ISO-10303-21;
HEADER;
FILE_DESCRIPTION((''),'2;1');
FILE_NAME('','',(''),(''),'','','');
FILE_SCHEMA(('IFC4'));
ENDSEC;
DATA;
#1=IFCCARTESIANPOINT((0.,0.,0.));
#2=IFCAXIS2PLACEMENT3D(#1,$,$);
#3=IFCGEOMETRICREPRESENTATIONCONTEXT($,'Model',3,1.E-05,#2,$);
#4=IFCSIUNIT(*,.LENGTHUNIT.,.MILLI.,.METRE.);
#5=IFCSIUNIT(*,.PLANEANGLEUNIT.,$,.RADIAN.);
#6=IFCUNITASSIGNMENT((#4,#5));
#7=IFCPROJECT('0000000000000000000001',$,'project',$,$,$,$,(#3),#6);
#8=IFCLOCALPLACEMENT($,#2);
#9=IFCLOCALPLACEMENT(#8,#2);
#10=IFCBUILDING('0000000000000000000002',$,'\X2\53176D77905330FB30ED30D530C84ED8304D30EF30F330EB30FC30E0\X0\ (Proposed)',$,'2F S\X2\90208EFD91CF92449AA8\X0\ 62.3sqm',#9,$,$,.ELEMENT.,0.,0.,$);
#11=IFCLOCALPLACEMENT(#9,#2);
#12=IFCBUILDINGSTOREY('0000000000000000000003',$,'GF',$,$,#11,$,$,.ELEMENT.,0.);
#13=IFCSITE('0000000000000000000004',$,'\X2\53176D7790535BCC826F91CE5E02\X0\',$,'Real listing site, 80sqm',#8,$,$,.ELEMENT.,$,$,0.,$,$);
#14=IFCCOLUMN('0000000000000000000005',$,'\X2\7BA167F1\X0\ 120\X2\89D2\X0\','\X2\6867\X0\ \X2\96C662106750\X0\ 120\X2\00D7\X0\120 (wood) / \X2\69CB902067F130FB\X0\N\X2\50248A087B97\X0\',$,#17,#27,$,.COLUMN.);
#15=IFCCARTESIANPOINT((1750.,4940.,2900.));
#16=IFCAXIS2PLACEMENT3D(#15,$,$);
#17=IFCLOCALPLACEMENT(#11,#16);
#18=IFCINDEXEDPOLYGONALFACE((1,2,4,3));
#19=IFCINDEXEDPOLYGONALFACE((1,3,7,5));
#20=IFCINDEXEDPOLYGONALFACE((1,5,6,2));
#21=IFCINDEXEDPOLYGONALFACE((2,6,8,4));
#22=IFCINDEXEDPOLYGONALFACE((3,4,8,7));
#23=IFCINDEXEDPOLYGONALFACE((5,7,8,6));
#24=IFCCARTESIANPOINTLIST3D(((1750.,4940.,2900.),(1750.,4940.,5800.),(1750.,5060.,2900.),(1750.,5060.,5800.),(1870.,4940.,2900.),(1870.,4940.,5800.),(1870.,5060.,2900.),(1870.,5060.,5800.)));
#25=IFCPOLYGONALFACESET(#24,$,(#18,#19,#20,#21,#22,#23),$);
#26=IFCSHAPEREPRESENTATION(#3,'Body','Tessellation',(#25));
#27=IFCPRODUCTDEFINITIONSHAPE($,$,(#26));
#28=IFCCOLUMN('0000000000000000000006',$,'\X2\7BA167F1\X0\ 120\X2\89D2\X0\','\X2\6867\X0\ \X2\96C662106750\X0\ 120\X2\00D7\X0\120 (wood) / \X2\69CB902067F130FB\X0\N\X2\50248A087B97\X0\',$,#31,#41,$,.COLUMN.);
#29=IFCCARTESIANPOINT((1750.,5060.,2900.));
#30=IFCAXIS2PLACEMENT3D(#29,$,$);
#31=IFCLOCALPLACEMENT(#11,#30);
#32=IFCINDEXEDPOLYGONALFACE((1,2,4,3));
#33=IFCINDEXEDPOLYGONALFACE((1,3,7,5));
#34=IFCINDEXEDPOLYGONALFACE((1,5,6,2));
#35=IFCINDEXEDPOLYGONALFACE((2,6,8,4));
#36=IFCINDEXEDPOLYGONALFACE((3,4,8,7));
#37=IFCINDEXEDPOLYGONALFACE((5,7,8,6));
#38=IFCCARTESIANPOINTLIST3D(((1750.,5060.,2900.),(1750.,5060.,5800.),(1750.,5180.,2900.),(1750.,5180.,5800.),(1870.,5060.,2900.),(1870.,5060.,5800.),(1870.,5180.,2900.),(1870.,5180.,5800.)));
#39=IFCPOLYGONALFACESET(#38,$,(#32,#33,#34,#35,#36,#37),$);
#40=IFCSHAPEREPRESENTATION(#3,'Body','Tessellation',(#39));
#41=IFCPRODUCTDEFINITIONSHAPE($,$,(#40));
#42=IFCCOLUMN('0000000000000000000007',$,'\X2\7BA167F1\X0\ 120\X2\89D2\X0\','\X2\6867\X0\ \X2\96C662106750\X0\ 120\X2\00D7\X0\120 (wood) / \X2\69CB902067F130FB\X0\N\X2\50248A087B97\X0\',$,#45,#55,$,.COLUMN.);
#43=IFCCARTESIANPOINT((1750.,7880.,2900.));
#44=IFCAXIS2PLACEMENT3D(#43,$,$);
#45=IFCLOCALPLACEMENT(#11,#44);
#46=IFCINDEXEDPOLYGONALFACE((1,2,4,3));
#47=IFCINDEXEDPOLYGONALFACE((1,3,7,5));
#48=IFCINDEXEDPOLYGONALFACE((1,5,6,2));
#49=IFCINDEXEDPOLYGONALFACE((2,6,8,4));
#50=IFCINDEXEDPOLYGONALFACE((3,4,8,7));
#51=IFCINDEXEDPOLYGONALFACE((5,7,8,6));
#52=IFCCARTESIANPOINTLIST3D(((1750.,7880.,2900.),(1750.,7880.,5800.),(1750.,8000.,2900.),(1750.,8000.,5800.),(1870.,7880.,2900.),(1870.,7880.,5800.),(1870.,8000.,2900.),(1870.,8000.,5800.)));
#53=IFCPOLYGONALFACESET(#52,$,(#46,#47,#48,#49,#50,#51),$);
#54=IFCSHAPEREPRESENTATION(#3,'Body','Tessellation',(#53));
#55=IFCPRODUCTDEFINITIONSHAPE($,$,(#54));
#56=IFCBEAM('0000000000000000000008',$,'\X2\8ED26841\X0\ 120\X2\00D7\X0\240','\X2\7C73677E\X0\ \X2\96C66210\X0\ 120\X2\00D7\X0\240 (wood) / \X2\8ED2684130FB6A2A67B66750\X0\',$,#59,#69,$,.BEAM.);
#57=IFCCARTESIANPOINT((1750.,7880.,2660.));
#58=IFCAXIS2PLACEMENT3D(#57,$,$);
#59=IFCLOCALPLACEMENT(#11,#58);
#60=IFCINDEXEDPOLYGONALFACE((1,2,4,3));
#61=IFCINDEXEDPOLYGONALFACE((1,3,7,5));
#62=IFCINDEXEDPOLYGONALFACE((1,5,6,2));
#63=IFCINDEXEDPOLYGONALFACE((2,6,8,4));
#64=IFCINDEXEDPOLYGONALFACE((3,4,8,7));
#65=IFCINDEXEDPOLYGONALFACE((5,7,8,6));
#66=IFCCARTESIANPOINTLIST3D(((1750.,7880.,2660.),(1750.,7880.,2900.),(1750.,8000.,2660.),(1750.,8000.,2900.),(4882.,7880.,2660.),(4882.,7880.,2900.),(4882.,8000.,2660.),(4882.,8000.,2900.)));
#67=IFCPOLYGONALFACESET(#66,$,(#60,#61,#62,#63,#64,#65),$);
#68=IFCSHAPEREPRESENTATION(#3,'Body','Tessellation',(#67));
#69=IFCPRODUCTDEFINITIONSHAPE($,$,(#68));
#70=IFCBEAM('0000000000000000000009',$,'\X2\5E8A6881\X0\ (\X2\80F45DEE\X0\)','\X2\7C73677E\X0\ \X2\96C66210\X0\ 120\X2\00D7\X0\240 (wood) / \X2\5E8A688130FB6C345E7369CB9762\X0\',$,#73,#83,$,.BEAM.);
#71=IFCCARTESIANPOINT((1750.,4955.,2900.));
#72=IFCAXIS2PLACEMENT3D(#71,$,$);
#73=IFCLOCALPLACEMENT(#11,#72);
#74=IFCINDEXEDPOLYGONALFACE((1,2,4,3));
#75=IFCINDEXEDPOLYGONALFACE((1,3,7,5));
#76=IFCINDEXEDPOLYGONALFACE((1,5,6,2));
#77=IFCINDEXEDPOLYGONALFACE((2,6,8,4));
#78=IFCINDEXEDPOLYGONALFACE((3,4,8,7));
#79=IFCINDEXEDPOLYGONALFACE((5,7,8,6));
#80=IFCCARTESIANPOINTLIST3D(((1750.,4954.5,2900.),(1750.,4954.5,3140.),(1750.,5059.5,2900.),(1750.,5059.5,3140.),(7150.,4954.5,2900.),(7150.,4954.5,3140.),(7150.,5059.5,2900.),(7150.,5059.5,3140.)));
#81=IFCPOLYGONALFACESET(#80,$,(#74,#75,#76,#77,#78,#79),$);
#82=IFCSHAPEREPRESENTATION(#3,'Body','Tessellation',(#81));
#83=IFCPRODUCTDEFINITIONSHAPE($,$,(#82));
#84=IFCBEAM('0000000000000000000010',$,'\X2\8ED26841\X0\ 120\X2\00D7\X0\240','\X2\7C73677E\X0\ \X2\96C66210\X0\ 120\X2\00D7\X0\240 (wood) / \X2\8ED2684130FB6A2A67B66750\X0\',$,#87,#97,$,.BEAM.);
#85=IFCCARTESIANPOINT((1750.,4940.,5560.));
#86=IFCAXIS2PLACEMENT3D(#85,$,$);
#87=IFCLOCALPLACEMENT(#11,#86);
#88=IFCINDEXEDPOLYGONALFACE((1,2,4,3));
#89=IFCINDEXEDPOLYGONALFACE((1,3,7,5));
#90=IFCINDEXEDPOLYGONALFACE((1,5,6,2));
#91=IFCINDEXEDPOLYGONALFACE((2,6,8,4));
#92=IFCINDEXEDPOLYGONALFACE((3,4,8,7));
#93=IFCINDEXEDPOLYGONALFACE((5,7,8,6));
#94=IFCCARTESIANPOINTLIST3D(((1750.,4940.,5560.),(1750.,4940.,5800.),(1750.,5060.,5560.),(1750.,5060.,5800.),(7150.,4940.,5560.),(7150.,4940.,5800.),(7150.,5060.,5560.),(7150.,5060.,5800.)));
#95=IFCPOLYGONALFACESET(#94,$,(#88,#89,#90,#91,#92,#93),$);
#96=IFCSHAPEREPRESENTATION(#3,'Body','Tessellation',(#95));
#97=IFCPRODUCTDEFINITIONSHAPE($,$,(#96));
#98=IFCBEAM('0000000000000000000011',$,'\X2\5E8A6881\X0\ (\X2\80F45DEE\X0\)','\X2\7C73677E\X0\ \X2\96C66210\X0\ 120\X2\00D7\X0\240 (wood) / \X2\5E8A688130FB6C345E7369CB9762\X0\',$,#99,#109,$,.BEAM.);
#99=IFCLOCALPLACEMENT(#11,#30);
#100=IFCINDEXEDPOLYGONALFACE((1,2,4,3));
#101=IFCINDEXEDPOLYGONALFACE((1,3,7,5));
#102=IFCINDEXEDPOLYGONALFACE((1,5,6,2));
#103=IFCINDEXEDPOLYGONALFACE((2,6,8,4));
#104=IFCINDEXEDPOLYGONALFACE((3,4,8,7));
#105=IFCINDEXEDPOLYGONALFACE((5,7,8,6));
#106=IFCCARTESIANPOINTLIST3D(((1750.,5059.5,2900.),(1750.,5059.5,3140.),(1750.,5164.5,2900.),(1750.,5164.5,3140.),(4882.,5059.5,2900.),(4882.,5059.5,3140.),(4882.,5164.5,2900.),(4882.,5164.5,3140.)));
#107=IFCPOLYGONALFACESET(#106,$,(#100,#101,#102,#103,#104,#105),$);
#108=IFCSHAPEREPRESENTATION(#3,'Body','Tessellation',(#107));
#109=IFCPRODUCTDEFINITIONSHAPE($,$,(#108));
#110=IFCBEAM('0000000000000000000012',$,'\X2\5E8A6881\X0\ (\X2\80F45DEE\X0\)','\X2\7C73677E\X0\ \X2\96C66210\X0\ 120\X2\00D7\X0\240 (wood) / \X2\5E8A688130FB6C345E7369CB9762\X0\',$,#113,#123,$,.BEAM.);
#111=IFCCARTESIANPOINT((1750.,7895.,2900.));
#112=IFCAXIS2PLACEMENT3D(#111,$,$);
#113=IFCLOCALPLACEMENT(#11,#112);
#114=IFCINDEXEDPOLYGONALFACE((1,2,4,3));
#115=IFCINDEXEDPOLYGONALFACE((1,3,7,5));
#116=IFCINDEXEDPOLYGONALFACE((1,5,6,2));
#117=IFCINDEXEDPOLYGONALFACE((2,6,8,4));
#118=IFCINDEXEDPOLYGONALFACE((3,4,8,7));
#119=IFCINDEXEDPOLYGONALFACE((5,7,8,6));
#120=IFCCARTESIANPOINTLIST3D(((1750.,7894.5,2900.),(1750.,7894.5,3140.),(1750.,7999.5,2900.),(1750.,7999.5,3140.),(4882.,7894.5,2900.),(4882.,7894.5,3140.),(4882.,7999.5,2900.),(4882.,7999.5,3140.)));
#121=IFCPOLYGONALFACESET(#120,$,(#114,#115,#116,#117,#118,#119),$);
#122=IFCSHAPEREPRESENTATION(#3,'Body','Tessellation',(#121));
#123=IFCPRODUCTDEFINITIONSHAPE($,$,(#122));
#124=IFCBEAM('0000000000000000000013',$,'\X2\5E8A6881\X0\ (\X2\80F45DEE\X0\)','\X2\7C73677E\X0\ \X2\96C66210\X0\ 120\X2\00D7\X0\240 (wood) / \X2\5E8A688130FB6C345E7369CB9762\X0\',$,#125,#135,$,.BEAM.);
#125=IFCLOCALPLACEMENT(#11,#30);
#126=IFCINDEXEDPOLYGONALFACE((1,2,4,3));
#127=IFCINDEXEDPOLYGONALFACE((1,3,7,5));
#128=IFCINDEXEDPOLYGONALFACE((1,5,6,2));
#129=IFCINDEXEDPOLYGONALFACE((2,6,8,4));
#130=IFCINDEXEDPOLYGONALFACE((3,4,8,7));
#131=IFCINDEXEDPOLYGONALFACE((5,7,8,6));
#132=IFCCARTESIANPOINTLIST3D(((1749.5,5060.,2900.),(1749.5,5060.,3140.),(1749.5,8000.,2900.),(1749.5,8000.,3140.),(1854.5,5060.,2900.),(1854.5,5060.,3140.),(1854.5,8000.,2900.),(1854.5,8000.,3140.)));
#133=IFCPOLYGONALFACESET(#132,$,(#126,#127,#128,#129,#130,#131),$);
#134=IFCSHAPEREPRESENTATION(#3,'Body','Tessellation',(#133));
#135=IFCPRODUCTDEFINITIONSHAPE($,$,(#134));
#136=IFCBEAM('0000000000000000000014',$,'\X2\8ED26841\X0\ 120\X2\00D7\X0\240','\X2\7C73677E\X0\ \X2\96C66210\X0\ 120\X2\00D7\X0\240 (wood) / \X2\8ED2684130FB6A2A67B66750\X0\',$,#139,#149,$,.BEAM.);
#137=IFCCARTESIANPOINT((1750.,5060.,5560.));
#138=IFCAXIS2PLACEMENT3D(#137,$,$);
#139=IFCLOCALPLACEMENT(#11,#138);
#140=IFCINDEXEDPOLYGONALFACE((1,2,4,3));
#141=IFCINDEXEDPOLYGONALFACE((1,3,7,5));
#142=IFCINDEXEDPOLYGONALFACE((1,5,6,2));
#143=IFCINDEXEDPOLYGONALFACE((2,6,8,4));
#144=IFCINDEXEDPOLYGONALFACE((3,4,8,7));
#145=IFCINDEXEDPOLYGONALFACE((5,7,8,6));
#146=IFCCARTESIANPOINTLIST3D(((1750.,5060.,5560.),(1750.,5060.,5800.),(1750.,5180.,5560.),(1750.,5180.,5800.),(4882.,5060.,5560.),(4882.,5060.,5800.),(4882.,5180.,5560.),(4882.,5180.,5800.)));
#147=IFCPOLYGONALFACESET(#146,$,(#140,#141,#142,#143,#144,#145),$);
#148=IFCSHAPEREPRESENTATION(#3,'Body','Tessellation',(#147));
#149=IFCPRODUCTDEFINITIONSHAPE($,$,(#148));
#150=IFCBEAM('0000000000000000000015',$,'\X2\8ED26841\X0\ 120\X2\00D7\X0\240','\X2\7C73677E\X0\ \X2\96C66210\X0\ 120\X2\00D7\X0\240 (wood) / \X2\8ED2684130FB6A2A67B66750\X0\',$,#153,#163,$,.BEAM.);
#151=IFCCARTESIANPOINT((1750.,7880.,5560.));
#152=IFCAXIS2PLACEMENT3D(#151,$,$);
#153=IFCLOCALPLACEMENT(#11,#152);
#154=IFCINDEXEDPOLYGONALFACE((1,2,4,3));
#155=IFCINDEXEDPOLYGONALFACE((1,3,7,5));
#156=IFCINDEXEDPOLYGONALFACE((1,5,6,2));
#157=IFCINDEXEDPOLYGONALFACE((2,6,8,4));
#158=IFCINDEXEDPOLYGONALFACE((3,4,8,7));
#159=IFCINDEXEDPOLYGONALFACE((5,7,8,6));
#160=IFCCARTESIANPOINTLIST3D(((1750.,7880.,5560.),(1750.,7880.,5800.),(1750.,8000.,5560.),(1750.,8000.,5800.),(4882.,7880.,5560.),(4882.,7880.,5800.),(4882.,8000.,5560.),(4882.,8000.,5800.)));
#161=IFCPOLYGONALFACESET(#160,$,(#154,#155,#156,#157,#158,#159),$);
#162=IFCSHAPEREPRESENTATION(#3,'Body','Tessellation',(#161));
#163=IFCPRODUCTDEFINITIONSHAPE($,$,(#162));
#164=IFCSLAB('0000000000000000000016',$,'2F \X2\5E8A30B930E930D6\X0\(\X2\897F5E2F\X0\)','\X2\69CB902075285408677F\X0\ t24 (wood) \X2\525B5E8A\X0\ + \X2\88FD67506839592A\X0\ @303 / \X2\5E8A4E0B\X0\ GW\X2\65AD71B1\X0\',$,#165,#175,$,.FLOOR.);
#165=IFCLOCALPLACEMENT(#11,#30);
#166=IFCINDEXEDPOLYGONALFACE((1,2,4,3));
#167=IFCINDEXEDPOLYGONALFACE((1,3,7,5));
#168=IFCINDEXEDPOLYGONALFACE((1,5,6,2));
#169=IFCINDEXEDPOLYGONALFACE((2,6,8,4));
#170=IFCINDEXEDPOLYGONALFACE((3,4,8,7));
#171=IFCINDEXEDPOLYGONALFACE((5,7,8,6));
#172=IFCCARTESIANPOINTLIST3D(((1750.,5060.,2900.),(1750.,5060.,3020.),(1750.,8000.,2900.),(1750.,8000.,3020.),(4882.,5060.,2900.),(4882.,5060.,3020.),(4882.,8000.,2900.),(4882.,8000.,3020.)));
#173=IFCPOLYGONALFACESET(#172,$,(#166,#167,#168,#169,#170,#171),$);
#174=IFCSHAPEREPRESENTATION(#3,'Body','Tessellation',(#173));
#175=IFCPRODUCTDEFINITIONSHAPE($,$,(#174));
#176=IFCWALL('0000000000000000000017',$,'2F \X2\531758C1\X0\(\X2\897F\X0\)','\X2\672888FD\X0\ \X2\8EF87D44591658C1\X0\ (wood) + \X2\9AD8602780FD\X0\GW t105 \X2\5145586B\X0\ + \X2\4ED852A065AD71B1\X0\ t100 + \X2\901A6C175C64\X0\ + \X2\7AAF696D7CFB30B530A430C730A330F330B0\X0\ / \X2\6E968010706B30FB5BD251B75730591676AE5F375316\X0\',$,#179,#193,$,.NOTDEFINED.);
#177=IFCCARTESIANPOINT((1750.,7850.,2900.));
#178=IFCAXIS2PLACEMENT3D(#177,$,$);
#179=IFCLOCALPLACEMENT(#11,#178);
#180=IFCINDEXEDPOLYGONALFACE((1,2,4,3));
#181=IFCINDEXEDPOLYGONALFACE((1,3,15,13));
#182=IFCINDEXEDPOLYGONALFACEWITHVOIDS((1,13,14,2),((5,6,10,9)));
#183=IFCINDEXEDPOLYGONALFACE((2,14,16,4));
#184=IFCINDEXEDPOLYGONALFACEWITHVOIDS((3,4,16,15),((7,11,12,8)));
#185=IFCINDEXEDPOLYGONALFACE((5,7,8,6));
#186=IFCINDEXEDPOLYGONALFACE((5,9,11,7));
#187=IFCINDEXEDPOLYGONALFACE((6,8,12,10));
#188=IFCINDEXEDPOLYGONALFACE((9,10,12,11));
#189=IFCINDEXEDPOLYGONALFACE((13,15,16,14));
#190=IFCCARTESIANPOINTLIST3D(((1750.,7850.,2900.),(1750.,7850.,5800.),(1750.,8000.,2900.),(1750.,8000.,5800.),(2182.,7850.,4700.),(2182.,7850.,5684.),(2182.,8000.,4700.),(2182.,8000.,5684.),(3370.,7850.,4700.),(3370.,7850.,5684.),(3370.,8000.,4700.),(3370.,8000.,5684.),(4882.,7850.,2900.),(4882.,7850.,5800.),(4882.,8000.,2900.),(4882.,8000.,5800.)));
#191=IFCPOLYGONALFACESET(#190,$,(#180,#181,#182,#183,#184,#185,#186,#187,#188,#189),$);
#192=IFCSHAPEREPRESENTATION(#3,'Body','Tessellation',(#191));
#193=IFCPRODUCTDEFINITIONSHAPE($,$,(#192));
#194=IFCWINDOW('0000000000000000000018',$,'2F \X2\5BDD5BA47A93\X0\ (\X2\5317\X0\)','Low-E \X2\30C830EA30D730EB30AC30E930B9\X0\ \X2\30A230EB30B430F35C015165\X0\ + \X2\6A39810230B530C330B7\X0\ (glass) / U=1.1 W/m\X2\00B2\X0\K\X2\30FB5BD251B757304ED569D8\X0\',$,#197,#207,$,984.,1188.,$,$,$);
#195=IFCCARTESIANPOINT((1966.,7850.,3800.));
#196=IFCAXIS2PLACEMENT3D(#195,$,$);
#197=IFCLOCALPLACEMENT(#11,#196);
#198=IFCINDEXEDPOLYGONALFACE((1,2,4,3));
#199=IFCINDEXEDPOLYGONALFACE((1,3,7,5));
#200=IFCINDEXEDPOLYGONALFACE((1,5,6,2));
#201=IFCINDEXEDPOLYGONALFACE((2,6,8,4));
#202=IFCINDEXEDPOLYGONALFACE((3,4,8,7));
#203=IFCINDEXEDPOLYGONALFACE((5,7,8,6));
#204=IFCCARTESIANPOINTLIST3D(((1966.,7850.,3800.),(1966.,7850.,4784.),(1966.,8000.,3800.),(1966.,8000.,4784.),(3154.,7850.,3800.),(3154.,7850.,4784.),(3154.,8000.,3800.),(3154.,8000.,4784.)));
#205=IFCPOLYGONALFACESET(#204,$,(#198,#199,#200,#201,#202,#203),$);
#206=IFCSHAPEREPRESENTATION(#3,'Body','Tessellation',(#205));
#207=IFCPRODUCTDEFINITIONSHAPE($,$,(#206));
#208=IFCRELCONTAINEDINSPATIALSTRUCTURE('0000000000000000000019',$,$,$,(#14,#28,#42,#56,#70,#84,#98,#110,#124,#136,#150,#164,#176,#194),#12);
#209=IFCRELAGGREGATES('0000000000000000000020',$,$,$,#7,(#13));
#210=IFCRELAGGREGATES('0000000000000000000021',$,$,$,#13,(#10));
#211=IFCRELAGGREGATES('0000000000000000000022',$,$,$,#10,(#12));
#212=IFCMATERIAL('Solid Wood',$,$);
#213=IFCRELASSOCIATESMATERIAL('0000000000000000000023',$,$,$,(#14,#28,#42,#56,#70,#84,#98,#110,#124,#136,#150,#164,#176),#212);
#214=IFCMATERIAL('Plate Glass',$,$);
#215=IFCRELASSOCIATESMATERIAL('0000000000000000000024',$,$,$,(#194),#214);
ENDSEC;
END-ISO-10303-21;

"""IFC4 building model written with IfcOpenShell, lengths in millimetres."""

from ifc_helpers import new_model, si_unit, frame, frame_2d, origin, place, context, project, spatial, rectangle, extrude, material, element, fill, save


model = new_model("IFC4")

# Units and contexts
model_context = context("Model", 3, precision=1e-05, world=origin())
ifc_project = project(units=[si_unit("LENGTHUNIT", "METRE", prefix="MILLI"), si_unit("PLANEANGLEUNIT", "RADIAN")], contexts=[model_context])

# Site, building, storey
site_placement = place(None, origin())
site = spatial("IfcSite", under=ifc_project, at=site_placement, Name="北海道富良野市", ObjectType="Real listing site, 80sqm", CompositionType="ELEMENT", RefElevation=0.0)
building_placement = place(site_placement, origin())
building = spatial("IfcBuilding", under=site, at=building_placement, Name="北海道・ロフト付きワンルーム (Proposed)", ObjectType="2F S造軽量鉄骨 62.3sqm", CompositionType="ELEMENT", ElevationOfRefHeight=0.0, ElevationOfTerrain=0.0)
storey_placement = place(building_placement, origin())
storey = spatial("IfcBuildingStorey", under=building, at=storey_placement, Name="GF", CompositionType="ELEMENT", Elevation=0.0)

# Columns
ifc_material_1 = material(Name="Solid Wood")
column_1_placement = place(storey_placement, frame((1750.0, 4940.0, 2900.0)))
element("IfcColumn", 1, at=column_1_placement, inside=storey, material=ifc_material_1, Name="管柱 120角", Description="桧 集成材 120×120 (wood) / 構造柱・N値計算", PredefinedType="COLUMN", context=model_context, shape_type="SweptSolid", body=[
    extrude(rectangle(XDim=120.0, YDim=120.0, at=frame_2d((60.0, 60.0))), frame((1750.0, 4940.0, 2900.0)), (0.0, 0.0, 1.0), 2900.0),
])
column_2_placement = place(storey_placement, frame((1750.0, 5060.0, 2900.0)))
element("IfcColumn", 2, at=column_2_placement, inside=storey, material=ifc_material_1, Name="管柱 120角", Description="桧 集成材 120×120 (wood) / 構造柱・N値計算", PredefinedType="COLUMN", context=model_context, shape_type="SweptSolid", body=[
    extrude(rectangle(XDim=120.0, YDim=120.0, at=frame_2d((60.0, 60.0))), frame((1750.0, 5060.0, 2900.0)), (0.0, 0.0, 1.0), 2900.0),
])
column_3_placement = place(storey_placement, frame((1750.0, 7880.0, 2900.0)))
element("IfcColumn", 3, at=column_3_placement, inside=storey, material=ifc_material_1, Name="管柱 120角", Description="桧 集成材 120×120 (wood) / 構造柱・N値計算", PredefinedType="COLUMN", context=model_context, shape_type="SweptSolid", body=[
    extrude(rectangle(XDim=120.0, YDim=120.0, at=frame_2d((60.0, 60.0))), frame((1750.0, 7880.0, 2900.0)), (0.0, 0.0, 1.0), 2900.0),
])

# Beams
beam_1_placement = place(storey_placement, frame((1750.0, 7880.0, 2660.0)))
element("IfcBeam", 4, at=beam_1_placement, inside=storey, material=ifc_material_1, Name="軒桁 120×240", Description="米松 集成 120×240 (wood) / 軒桁・横架材", PredefinedType="BEAM", context=model_context, shape_type="SweptSolid", body=[
    extrude(rectangle(XDim=3132.0, YDim=120.0, at=frame_2d((1566.0, 60.0))), frame((1750.0, 7880.0, 2660.0)), (0.0, 0.0, 1.0), 240.0),
])
beam_2_placement = place(storey_placement, frame((1750.0, 4955.0, 2900.0)))
element("IfcBeam", 5, at=beam_2_placement, inside=storey, material=ifc_material_1, Name="床梁 (胴差)", Description="米松 集成 120×240 (wood) / 床梁・水平構面", PredefinedType="BEAM", context=model_context, shape_type="SweptSolid", body=[
    extrude(rectangle(XDim=5400.0, YDim=105.0, at=frame_2d((2700.0, 52.0))), frame((1750.0, 4955.0, 2900.0)), (0.0, 0.0, 1.0), 240.0),
])
beam_3_placement = place(storey_placement, frame((1750.0, 4940.0, 5560.0)))
element("IfcBeam", 6, at=beam_3_placement, inside=storey, material=ifc_material_1, Name="軒桁 120×240", Description="米松 集成 120×240 (wood) / 軒桁・横架材", PredefinedType="BEAM", context=model_context, shape_type="SweptSolid", body=[
    extrude(rectangle(XDim=5400.0, YDim=120.0, at=frame_2d((2700.0, 60.0))), frame((1750.0, 4940.0, 5560.0)), (0.0, 0.0, 1.0), 240.0),
])
beam_4_placement = place(storey_placement, frame((1750.0, 5060.0, 2900.0)))
element("IfcBeam", 7, at=beam_4_placement, inside=storey, material=ifc_material_1, Name="床梁 (胴差)", Description="米松 集成 120×240 (wood) / 床梁・水平構面", PredefinedType="BEAM", context=model_context, shape_type="SweptSolid", body=[
    extrude(rectangle(XDim=3132.0, YDim=105.0, at=frame_2d((1566.0, 52.0))), frame((1750.0, 5060.0, 2900.0)), (0.0, 0.0, 1.0), 240.0),
])
beam_5_placement = place(storey_placement, frame((1750.0, 7895.0, 2900.0)))
element("IfcBeam", 8, at=beam_5_placement, inside=storey, material=ifc_material_1, Name="床梁 (胴差)", Description="米松 集成 120×240 (wood) / 床梁・水平構面", PredefinedType="BEAM", context=model_context, shape_type="SweptSolid", body=[
    extrude(rectangle(XDim=3132.0, YDim=105.0, at=frame_2d((1566.0, 52.0))), frame((1750.0, 7895.0, 2900.0)), (0.0, 0.0, 1.0), 240.0),
])
beam_6_placement = place(storey_placement, frame((1750.0, 5060.0, 2900.0)))
element("IfcBeam", 9, at=beam_6_placement, inside=storey, material=ifc_material_1, Name="床梁 (胴差)", Description="米松 集成 120×240 (wood) / 床梁・水平構面", PredefinedType="BEAM", context=model_context, shape_type="SweptSolid", body=[
    extrude(rectangle(XDim=105.0, YDim=2940.0, at=frame_2d((52.0, 1470.0))), frame((1750.0, 5060.0, 2900.0)), (0.0, 0.0, 1.0), 240.0),
])
beam_7_placement = place(storey_placement, frame((1750.0, 5060.0, 5560.0)))
element("IfcBeam", 10, at=beam_7_placement, inside=storey, material=ifc_material_1, Name="軒桁 120×240", Description="米松 集成 120×240 (wood) / 軒桁・横架材", PredefinedType="BEAM", context=model_context, shape_type="SweptSolid", body=[
    extrude(rectangle(XDim=3132.0, YDim=120.0, at=frame_2d((1566.0, 60.0))), frame((1750.0, 5060.0, 5560.0)), (0.0, 0.0, 1.0), 240.0),
])
beam_8_placement = place(storey_placement, frame((1750.0, 7880.0, 5560.0)))
element("IfcBeam", 11, at=beam_8_placement, inside=storey, material=ifc_material_1, Name="軒桁 120×240", Description="米松 集成 120×240 (wood) / 軒桁・横架材", PredefinedType="BEAM", context=model_context, shape_type="SweptSolid", body=[
    extrude(rectangle(XDim=3132.0, YDim=120.0, at=frame_2d((1566.0, 60.0))), frame((1750.0, 7880.0, 5560.0)), (0.0, 0.0, 1.0), 240.0),
])

# Slab
slab_placement = place(storey_placement, frame((1750.0, 5060.0, 2900.0)))
element("IfcSlab", 12, at=slab_placement, inside=storey, material=ifc_material_1, Name="2F 床スラブ(西帯)", Description="構造用合板 t24 (wood) 剛床 + 製材根太 @303 / 床下 GW断熱", PredefinedType="FLOOR", context=model_context, shape_type="SweptSolid", body=[
    extrude(rectangle(XDim=3132.0, YDim=2940.0, at=frame_2d((1566.0, 1470.0))), frame((1750.0, 5060.0, 2900.0)), (0.0, 0.0, 1.0), 120.0),
])

# Wall, opening, window
wall_1_placement = place(storey_placement, frame((1750.0, 7850.0, 2900.0)))
wall_1 = element("IfcWall", 13, at=wall_1_placement, inside=storey, material=ifc_material_1, Name="2F 北壁(西)", Description="木製 軸組外壁 (wood) + 高性能GW t105 充填 + 付加断熱 t100 + 通気層 + 窯業系サイディング / 準耐火・寒冷地外皮強化", PredefinedType="NOTDEFINED", context=model_context, shape_type="SweptSolid", body=[
    extrude(rectangle(XDim=3132.0, YDim=150.0, at=frame_2d((1566.0, 75.0))), frame((1750.0, 7850.0, 2900.0)), (0.0, 0.0, 1.0), 2900.0),
])
opening_placement = place(storey_placement, frame((1966.0, 7850.0, 3800.0)))
opening = element("IfcOpeningElement", 14, at=opening_placement, cuts=wall_1, PredefinedType="NOTDEFINED", context=model_context, shape_type="SweptSolid", body=[
    extrude(rectangle(XDim=1188.0, YDim=150.0, at=frame_2d((594.0, 75.0))), frame((1966.0, 7850.0, 3800.0)), (0.0, 0.0, 1.0), 984.0),
])
ifc_material_2 = material(Name="Plate Glass")
window_placement = place(storey_placement, frame((1966.0, 7850.0, 3800.0)))
window = element("IfcWindow", 15, at=window_placement, inside=storey, material=ifc_material_2, Name="2F 寝室窓 (北)", Description="Low-E トリプルガラス アルゴン封入 + 樹脂サッシ (glass) / U=1.1 W/m²K・寒冷地仕様", OverallHeight=984.0, OverallWidth=1188.0, context=model_context, shape_type="SweptSolid", body=[
    extrude(rectangle(XDim=1188.0, YDim=150.0, at=frame_2d((594.0, 75.0))), frame((1966.0, 7850.0, 3800.0)), (0.0, 0.0, 1.0), 984.0),
])
fill(opening, window)

save(model, "model.ifc")
